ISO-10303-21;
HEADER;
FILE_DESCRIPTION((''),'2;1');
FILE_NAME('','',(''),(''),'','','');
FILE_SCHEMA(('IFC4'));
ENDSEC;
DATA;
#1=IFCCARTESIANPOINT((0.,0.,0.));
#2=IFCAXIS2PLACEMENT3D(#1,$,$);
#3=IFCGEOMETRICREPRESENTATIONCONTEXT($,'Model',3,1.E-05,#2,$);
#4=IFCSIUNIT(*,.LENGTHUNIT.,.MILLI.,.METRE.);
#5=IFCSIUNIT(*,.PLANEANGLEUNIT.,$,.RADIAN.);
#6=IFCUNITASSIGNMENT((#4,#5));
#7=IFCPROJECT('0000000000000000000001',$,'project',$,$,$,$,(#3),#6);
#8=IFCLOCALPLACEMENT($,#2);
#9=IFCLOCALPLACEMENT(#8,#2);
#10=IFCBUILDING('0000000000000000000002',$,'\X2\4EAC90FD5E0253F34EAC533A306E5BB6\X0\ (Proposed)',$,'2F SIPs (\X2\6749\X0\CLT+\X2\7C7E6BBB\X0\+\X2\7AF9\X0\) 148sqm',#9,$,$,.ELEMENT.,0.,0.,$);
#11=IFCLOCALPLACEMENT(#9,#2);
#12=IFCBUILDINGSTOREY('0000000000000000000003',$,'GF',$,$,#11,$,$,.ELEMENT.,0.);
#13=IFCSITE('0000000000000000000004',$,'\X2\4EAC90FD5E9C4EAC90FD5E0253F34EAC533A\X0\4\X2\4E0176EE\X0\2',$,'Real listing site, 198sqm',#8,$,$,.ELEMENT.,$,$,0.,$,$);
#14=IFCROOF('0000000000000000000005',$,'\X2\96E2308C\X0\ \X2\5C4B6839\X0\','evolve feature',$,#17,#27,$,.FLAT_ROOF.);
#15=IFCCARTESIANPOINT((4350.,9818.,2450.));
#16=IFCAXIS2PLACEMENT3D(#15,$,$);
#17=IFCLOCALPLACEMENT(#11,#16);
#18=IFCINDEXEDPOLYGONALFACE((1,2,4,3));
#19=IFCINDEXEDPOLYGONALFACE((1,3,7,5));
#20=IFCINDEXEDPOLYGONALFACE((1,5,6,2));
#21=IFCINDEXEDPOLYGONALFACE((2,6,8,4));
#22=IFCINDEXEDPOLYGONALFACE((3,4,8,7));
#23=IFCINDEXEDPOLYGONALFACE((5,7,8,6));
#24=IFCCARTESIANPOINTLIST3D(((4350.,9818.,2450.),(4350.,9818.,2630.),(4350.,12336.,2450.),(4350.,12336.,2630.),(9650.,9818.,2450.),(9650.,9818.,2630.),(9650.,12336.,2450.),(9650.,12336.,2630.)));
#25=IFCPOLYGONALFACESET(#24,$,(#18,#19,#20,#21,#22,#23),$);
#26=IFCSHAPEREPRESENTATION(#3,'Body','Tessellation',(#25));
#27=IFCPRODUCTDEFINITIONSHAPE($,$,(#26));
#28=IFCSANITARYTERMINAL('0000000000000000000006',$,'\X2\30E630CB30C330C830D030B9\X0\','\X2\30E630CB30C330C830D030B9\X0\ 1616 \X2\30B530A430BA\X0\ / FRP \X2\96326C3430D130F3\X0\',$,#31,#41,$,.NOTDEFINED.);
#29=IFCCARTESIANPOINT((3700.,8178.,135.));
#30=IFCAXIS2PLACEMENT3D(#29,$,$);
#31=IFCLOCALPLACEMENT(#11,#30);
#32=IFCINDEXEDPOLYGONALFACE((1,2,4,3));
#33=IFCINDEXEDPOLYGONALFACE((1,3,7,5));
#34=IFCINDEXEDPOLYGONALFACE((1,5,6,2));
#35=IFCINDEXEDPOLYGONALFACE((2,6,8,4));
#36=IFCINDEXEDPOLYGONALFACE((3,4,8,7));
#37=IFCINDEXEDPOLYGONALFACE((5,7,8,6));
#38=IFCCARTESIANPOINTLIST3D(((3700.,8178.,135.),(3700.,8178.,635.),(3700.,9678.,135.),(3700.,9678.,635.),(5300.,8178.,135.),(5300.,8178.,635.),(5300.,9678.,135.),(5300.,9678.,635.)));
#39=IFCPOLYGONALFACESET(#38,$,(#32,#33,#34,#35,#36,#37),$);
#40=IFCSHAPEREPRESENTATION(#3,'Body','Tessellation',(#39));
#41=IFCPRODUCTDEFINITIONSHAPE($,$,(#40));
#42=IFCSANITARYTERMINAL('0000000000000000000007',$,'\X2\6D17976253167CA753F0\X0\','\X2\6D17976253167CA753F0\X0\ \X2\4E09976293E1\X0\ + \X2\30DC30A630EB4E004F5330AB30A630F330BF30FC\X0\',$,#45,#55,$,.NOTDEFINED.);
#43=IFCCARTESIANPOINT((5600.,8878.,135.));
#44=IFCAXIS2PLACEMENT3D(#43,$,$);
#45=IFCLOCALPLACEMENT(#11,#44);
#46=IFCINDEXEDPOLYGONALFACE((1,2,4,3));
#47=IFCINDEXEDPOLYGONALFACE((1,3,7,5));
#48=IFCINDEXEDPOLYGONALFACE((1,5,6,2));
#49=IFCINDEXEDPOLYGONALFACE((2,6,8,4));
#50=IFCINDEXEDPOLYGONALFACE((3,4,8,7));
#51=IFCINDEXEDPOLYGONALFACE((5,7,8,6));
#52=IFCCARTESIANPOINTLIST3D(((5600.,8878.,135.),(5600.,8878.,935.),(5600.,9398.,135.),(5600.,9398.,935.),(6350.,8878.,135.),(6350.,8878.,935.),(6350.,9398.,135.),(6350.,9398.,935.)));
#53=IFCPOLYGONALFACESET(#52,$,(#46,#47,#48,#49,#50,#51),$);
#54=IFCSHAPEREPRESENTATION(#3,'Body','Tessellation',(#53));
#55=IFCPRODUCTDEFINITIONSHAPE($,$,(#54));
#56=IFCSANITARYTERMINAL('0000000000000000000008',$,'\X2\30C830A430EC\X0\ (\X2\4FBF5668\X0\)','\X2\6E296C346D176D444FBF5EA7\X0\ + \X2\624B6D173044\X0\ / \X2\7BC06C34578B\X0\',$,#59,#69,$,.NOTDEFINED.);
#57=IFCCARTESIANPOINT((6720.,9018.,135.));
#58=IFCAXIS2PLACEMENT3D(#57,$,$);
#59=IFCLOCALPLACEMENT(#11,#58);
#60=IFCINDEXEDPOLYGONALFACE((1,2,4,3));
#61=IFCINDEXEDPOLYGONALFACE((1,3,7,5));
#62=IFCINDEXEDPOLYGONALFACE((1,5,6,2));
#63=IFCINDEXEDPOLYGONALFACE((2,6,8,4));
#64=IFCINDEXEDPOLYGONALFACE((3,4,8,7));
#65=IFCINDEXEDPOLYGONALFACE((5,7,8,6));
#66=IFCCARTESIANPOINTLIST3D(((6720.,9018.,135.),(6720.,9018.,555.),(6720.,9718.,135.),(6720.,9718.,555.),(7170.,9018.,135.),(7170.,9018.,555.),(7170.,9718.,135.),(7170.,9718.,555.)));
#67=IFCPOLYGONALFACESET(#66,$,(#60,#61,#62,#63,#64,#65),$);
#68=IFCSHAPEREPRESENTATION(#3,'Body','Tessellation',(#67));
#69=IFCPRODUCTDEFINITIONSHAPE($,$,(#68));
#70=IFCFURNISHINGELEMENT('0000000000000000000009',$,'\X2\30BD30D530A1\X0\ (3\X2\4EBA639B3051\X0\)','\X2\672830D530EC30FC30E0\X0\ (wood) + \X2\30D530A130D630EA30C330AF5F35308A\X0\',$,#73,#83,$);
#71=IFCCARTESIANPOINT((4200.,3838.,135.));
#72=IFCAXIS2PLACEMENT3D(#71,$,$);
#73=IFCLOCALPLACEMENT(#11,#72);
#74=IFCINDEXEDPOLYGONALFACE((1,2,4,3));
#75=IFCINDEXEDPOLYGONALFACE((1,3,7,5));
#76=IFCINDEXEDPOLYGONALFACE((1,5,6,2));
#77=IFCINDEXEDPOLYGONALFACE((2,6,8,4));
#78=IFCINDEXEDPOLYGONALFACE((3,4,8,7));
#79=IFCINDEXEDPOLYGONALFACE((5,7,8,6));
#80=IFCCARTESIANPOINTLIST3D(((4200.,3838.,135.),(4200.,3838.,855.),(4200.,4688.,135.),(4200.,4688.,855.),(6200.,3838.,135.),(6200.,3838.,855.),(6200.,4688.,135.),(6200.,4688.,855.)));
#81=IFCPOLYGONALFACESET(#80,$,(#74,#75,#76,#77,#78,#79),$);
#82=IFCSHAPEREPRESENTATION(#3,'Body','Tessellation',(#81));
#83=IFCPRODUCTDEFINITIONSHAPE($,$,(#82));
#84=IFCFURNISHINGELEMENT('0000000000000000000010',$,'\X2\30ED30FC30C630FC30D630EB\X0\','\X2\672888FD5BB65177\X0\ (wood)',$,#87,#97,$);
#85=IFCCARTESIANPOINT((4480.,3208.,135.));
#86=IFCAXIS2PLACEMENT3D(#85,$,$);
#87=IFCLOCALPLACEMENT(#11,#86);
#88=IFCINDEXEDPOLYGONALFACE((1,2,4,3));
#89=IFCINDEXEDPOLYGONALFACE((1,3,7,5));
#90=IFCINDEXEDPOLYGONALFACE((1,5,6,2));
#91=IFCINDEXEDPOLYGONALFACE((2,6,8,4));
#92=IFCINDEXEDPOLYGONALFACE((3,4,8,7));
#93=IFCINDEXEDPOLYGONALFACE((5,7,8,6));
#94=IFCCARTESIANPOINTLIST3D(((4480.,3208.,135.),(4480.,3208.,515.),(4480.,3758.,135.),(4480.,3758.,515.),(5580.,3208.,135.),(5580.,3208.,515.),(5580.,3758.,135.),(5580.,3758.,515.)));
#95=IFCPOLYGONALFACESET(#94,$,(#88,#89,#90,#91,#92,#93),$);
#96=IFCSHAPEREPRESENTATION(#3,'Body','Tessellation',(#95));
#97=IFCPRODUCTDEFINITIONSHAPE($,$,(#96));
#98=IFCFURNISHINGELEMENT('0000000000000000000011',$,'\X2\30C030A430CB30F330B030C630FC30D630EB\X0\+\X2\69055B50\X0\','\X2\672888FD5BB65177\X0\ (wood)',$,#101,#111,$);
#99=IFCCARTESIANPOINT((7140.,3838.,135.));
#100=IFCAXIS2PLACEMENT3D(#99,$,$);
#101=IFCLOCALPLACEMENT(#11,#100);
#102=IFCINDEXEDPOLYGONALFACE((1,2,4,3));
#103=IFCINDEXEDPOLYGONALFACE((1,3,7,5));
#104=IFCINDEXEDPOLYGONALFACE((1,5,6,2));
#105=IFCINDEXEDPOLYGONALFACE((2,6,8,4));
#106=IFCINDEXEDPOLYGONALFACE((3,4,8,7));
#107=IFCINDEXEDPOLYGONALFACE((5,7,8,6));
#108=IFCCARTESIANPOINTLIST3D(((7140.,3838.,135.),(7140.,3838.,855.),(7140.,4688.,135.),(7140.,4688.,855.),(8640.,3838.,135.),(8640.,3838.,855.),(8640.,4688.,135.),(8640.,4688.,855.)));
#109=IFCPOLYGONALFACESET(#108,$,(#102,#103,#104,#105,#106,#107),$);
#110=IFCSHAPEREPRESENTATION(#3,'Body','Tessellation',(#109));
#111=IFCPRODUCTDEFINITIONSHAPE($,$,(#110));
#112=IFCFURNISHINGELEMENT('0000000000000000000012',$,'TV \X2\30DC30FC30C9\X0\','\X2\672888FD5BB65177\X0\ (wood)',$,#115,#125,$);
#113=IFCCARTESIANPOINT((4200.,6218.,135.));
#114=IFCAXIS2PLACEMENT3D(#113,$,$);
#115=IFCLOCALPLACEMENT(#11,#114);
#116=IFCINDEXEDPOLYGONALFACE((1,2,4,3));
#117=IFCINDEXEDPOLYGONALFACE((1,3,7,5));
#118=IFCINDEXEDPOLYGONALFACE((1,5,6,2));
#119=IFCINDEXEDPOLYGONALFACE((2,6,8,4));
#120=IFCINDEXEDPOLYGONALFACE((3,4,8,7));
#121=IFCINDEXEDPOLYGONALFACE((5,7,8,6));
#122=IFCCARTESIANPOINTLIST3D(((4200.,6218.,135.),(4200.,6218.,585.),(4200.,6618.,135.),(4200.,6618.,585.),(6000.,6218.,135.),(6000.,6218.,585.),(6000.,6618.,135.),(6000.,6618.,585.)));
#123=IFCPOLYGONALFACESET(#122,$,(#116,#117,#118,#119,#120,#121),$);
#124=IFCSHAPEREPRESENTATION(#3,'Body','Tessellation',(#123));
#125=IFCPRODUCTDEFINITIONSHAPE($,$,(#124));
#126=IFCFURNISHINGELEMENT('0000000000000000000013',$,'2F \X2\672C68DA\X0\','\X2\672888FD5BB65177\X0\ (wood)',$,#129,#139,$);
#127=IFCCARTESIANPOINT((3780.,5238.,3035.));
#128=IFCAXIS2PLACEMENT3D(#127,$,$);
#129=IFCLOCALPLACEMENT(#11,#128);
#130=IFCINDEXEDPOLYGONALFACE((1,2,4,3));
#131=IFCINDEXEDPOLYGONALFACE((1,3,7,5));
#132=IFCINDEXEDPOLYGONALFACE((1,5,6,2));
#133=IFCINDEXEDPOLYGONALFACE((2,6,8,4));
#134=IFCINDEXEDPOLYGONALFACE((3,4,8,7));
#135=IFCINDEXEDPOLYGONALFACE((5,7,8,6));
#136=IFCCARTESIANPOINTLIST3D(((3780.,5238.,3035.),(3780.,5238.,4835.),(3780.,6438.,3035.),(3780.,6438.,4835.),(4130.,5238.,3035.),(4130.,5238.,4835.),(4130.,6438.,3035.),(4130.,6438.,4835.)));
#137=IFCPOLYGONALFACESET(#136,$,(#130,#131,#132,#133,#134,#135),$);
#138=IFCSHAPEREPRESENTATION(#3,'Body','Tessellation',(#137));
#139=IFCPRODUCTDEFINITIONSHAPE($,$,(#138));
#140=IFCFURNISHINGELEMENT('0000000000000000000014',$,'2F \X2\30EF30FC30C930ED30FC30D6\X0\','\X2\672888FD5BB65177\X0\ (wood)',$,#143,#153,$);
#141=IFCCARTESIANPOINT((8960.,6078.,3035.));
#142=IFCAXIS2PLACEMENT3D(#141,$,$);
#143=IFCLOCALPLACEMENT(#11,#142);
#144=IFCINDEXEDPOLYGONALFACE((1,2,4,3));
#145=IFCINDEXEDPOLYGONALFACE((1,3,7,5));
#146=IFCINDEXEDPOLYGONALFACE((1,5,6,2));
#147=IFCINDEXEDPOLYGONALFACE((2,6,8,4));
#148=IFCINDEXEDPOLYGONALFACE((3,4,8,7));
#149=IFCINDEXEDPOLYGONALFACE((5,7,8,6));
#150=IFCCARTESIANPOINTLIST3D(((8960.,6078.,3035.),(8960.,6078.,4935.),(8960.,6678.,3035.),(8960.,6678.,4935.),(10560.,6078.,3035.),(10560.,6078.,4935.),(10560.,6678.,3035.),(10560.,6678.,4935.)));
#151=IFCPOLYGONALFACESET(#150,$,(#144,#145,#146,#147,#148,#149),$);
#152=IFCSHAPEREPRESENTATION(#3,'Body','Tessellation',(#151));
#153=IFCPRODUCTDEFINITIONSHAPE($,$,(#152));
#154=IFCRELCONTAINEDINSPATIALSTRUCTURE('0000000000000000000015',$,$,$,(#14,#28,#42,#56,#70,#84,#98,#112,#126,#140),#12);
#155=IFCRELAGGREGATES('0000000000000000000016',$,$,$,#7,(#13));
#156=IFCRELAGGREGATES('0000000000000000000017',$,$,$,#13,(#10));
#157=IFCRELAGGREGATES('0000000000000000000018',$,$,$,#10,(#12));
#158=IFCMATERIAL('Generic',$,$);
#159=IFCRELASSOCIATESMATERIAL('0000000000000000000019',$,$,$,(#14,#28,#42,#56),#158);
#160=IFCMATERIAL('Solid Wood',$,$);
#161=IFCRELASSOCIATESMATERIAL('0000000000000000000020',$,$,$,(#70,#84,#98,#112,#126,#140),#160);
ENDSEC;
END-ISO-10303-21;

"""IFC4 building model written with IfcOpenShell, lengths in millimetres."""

from ifc_helpers import new_model, si_unit, frame, frame_2d, origin, place, context, project, spatial, rectangle, extrude, material, element, save


model = new_model("IFC4")

# Units and contexts
model_context = context("Model", 3, precision=1e-05, world=origin())
ifc_project = project(units=[si_unit("LENGTHUNIT", "METRE", prefix="MILLI"), si_unit("PLANEANGLEUNIT", "RADIAN")], contexts=[model_context])

# Site, building, storey
site_placement = place(None, origin())
site = spatial("IfcSite", under=ifc_project, at=site_placement, Name="京都府京都市右京区4丁目2", ObjectType="Real listing site, 198sqm", CompositionType="ELEMENT", RefElevation=0.0)
building_placement = place(site_placement, origin())
building = spatial("IfcBuilding", under=site, at=building_placement, Name="京都市右京区の家 (Proposed)", ObjectType="2F SIPs (杉CLT+籾殻+竹) 148sqm", CompositionType="ELEMENT", ElevationOfRefHeight=0.0, ElevationOfTerrain=0.0)
storey_placement = place(building_placement, origin())
storey = spatial("IfcBuildingStorey", under=building, at=storey_placement, Name="GF", CompositionType="ELEMENT", Elevation=0.0)

# Shared definitions
ifc_material_1 = material(Name="Generic")

# Shared definitions
ifc_material_2 = material(Name="Solid Wood")

# Roof
roof_placement = place(storey_placement, frame((4350.0, 9818.0, 2450.0)))
element("IfcRoof", 1, at=roof_placement, inside=storey, material=ifc_material_1, Name="離れ 屋根", Description="evolve feature", PredefinedType="FLAT_ROOF", context=model_context, shape_type="SweptSolid", body=[
    extrude(rectangle(XDim=5300.0, YDim=2518.0, at=frame_2d((2650.0, 1259.0))), frame((4350.0, 9818.0, 2450.0)), (0.0, 0.0, 1.0), 180.0),
])

# Sanitary terminals
sanitary_terminal_1_placement = place(storey_placement, frame((3700.0, 8178.0, 135.0)))
element("IfcSanitaryTerminal", 2, at=sanitary_terminal_1_placement, inside=storey, material=ifc_material_1, Name="ユニットバス", Description="ユニットバス 1616 サイズ / FRP 防水パン", PredefinedType="NOTDEFINED", context=model_context, shape_type="SweptSolid", body=[
    extrude(rectangle(XDim=1600.0, YDim=1500.0, at=frame_2d((800.0, 750.0))), frame((3700.0, 8178.0, 135.0)), (0.0, 0.0, 1.0), 500.0),
])
sanitary_terminal_2_placement = place(storey_placement, frame((5600.0, 8878.0, 135.0)))
element("IfcSanitaryTerminal", 3, at=sanitary_terminal_2_placement, inside=storey, material=ifc_material_1, Name="洗面化粧台", Description="洗面化粧台 三面鏡 + ボウル一体カウンター", PredefinedType="NOTDEFINED", context=model_context, shape_type="SweptSolid", body=[
    extrude(rectangle(XDim=750.0, YDim=520.0, at=frame_2d((375.0, 260.0))), frame((5600.0, 8878.0, 135.0)), (0.0, 0.0, 1.0), 800.0),
])
sanitary_terminal_3_placement = place(storey_placement, frame((6720.0, 9018.0, 135.0)))
element("IfcSanitaryTerminal", 4, at=sanitary_terminal_3_placement, inside=storey, material=ifc_material_1, Name="トイレ (便器)", Description="温水洗浄便座 + 手洗い / 節水型", PredefinedType="NOTDEFINED", context=model_context, shape_type="SweptSolid", body=[
    extrude(rectangle(XDim=450.0, YDim=700.0, at=frame_2d((225.0, 350.0))), frame((6720.0, 9018.0, 135.0)), (0.0, 0.0, 1.0), 420.0),
])

# Furnishing elements
furnishing_1_placement = place(storey_placement, frame((4200.0, 3838.0, 135.0)))
element("IfcFurnishingElement", 5, at=furnishing_1_placement, inside=storey, material=ifc_material_2, Name="ソファ (3人掛け)", Description="木フレーム (wood) + ファブリック張り", context=model_context, shape_type="SweptSolid", body=[
    extrude(rectangle(XDim=2000.0, YDim=850.0, at=frame_2d((1000.0, 425.0))), frame((4200.0, 3838.0, 135.0)), (0.0, 0.0, 1.0), 720.0),
])
furnishing_2_placement = place(storey_placement, frame((4480.0, 3208.0, 135.0)))
element("IfcFurnishingElement", 6, at=furnishing_2_placement, inside=storey, material=ifc_material_2, Name="ローテーブル", Description="木製家具 (wood)", context=model_context, shape_type="SweptSolid", body=[
    extrude(rectangle(XDim=1100.0, YDim=550.0, at=frame_2d((550.0, 275.0))), frame((4480.0, 3208.0, 135.0)), (0.0, 0.0, 1.0), 380.0),
])
furnishing_3_placement = place(storey_placement, frame((7140.0, 3838.0, 135.0)))
element("IfcFurnishingElement", 7, at=furnishing_3_placement, inside=storey, material=ifc_material_2, Name="ダイニングテーブル+椅子", Description="木製家具 (wood)", context=model_context, shape_type="SweptSolid", body=[
    extrude(rectangle(XDim=1500.0, YDim=850.0, at=frame_2d((750.0, 425.0))), frame((7140.0, 3838.0, 135.0)), (0.0, 0.0, 1.0), 720.0),
])
furnishing_4_placement = place(storey_placement, frame((4200.0, 6218.0, 135.0)))
element("IfcFurnishingElement", 8, at=furnishing_4_placement, inside=storey, material=ifc_material_2, Name="TV ボード", Description="木製家具 (wood)", context=model_context, shape_type="SweptSolid", body=[
    extrude(rectangle(XDim=1800.0, YDim=400.0, at=frame_2d((900.0, 200.0))), frame((4200.0, 6218.0, 135.0)), (0.0, 0.0, 1.0), 450.0),
])
furnishing_5_placement = place(storey_placement, frame((3780.0, 5238.0, 3035.0)))
element("IfcFurnishingElement", 9, at=furnishing_5_placement, inside=storey, material=ifc_material_2, Name="2F 本棚", Description="木製家具 (wood)", context=model_context, shape_type="SweptSolid", body=[
    extrude(rectangle(XDim=350.0, YDim=1200.0, at=frame_2d((175.0, 600.0))), frame((3780.0, 5238.0, 3035.0)), (0.0, 0.0, 1.0), 1800.0),
])
furnishing_6_placement = place(storey_placement, frame((8960.0, 6078.0, 3035.0)))
element("IfcFurnishingElement", 10, at=furnishing_6_placement, inside=storey, material=ifc_material_2, Name="2F ワードローブ", Description="木製家具 (wood)", context=model_context, shape_type="SweptSolid", body=[
    extrude(rectangle(XDim=1600.0, YDim=600.0, at=frame_2d((800.0, 300.0))), frame((8960.0, 6078.0, 3035.0)), (0.0, 0.0, 1.0), 1900.0),
])

save(model, "model.ifc")
